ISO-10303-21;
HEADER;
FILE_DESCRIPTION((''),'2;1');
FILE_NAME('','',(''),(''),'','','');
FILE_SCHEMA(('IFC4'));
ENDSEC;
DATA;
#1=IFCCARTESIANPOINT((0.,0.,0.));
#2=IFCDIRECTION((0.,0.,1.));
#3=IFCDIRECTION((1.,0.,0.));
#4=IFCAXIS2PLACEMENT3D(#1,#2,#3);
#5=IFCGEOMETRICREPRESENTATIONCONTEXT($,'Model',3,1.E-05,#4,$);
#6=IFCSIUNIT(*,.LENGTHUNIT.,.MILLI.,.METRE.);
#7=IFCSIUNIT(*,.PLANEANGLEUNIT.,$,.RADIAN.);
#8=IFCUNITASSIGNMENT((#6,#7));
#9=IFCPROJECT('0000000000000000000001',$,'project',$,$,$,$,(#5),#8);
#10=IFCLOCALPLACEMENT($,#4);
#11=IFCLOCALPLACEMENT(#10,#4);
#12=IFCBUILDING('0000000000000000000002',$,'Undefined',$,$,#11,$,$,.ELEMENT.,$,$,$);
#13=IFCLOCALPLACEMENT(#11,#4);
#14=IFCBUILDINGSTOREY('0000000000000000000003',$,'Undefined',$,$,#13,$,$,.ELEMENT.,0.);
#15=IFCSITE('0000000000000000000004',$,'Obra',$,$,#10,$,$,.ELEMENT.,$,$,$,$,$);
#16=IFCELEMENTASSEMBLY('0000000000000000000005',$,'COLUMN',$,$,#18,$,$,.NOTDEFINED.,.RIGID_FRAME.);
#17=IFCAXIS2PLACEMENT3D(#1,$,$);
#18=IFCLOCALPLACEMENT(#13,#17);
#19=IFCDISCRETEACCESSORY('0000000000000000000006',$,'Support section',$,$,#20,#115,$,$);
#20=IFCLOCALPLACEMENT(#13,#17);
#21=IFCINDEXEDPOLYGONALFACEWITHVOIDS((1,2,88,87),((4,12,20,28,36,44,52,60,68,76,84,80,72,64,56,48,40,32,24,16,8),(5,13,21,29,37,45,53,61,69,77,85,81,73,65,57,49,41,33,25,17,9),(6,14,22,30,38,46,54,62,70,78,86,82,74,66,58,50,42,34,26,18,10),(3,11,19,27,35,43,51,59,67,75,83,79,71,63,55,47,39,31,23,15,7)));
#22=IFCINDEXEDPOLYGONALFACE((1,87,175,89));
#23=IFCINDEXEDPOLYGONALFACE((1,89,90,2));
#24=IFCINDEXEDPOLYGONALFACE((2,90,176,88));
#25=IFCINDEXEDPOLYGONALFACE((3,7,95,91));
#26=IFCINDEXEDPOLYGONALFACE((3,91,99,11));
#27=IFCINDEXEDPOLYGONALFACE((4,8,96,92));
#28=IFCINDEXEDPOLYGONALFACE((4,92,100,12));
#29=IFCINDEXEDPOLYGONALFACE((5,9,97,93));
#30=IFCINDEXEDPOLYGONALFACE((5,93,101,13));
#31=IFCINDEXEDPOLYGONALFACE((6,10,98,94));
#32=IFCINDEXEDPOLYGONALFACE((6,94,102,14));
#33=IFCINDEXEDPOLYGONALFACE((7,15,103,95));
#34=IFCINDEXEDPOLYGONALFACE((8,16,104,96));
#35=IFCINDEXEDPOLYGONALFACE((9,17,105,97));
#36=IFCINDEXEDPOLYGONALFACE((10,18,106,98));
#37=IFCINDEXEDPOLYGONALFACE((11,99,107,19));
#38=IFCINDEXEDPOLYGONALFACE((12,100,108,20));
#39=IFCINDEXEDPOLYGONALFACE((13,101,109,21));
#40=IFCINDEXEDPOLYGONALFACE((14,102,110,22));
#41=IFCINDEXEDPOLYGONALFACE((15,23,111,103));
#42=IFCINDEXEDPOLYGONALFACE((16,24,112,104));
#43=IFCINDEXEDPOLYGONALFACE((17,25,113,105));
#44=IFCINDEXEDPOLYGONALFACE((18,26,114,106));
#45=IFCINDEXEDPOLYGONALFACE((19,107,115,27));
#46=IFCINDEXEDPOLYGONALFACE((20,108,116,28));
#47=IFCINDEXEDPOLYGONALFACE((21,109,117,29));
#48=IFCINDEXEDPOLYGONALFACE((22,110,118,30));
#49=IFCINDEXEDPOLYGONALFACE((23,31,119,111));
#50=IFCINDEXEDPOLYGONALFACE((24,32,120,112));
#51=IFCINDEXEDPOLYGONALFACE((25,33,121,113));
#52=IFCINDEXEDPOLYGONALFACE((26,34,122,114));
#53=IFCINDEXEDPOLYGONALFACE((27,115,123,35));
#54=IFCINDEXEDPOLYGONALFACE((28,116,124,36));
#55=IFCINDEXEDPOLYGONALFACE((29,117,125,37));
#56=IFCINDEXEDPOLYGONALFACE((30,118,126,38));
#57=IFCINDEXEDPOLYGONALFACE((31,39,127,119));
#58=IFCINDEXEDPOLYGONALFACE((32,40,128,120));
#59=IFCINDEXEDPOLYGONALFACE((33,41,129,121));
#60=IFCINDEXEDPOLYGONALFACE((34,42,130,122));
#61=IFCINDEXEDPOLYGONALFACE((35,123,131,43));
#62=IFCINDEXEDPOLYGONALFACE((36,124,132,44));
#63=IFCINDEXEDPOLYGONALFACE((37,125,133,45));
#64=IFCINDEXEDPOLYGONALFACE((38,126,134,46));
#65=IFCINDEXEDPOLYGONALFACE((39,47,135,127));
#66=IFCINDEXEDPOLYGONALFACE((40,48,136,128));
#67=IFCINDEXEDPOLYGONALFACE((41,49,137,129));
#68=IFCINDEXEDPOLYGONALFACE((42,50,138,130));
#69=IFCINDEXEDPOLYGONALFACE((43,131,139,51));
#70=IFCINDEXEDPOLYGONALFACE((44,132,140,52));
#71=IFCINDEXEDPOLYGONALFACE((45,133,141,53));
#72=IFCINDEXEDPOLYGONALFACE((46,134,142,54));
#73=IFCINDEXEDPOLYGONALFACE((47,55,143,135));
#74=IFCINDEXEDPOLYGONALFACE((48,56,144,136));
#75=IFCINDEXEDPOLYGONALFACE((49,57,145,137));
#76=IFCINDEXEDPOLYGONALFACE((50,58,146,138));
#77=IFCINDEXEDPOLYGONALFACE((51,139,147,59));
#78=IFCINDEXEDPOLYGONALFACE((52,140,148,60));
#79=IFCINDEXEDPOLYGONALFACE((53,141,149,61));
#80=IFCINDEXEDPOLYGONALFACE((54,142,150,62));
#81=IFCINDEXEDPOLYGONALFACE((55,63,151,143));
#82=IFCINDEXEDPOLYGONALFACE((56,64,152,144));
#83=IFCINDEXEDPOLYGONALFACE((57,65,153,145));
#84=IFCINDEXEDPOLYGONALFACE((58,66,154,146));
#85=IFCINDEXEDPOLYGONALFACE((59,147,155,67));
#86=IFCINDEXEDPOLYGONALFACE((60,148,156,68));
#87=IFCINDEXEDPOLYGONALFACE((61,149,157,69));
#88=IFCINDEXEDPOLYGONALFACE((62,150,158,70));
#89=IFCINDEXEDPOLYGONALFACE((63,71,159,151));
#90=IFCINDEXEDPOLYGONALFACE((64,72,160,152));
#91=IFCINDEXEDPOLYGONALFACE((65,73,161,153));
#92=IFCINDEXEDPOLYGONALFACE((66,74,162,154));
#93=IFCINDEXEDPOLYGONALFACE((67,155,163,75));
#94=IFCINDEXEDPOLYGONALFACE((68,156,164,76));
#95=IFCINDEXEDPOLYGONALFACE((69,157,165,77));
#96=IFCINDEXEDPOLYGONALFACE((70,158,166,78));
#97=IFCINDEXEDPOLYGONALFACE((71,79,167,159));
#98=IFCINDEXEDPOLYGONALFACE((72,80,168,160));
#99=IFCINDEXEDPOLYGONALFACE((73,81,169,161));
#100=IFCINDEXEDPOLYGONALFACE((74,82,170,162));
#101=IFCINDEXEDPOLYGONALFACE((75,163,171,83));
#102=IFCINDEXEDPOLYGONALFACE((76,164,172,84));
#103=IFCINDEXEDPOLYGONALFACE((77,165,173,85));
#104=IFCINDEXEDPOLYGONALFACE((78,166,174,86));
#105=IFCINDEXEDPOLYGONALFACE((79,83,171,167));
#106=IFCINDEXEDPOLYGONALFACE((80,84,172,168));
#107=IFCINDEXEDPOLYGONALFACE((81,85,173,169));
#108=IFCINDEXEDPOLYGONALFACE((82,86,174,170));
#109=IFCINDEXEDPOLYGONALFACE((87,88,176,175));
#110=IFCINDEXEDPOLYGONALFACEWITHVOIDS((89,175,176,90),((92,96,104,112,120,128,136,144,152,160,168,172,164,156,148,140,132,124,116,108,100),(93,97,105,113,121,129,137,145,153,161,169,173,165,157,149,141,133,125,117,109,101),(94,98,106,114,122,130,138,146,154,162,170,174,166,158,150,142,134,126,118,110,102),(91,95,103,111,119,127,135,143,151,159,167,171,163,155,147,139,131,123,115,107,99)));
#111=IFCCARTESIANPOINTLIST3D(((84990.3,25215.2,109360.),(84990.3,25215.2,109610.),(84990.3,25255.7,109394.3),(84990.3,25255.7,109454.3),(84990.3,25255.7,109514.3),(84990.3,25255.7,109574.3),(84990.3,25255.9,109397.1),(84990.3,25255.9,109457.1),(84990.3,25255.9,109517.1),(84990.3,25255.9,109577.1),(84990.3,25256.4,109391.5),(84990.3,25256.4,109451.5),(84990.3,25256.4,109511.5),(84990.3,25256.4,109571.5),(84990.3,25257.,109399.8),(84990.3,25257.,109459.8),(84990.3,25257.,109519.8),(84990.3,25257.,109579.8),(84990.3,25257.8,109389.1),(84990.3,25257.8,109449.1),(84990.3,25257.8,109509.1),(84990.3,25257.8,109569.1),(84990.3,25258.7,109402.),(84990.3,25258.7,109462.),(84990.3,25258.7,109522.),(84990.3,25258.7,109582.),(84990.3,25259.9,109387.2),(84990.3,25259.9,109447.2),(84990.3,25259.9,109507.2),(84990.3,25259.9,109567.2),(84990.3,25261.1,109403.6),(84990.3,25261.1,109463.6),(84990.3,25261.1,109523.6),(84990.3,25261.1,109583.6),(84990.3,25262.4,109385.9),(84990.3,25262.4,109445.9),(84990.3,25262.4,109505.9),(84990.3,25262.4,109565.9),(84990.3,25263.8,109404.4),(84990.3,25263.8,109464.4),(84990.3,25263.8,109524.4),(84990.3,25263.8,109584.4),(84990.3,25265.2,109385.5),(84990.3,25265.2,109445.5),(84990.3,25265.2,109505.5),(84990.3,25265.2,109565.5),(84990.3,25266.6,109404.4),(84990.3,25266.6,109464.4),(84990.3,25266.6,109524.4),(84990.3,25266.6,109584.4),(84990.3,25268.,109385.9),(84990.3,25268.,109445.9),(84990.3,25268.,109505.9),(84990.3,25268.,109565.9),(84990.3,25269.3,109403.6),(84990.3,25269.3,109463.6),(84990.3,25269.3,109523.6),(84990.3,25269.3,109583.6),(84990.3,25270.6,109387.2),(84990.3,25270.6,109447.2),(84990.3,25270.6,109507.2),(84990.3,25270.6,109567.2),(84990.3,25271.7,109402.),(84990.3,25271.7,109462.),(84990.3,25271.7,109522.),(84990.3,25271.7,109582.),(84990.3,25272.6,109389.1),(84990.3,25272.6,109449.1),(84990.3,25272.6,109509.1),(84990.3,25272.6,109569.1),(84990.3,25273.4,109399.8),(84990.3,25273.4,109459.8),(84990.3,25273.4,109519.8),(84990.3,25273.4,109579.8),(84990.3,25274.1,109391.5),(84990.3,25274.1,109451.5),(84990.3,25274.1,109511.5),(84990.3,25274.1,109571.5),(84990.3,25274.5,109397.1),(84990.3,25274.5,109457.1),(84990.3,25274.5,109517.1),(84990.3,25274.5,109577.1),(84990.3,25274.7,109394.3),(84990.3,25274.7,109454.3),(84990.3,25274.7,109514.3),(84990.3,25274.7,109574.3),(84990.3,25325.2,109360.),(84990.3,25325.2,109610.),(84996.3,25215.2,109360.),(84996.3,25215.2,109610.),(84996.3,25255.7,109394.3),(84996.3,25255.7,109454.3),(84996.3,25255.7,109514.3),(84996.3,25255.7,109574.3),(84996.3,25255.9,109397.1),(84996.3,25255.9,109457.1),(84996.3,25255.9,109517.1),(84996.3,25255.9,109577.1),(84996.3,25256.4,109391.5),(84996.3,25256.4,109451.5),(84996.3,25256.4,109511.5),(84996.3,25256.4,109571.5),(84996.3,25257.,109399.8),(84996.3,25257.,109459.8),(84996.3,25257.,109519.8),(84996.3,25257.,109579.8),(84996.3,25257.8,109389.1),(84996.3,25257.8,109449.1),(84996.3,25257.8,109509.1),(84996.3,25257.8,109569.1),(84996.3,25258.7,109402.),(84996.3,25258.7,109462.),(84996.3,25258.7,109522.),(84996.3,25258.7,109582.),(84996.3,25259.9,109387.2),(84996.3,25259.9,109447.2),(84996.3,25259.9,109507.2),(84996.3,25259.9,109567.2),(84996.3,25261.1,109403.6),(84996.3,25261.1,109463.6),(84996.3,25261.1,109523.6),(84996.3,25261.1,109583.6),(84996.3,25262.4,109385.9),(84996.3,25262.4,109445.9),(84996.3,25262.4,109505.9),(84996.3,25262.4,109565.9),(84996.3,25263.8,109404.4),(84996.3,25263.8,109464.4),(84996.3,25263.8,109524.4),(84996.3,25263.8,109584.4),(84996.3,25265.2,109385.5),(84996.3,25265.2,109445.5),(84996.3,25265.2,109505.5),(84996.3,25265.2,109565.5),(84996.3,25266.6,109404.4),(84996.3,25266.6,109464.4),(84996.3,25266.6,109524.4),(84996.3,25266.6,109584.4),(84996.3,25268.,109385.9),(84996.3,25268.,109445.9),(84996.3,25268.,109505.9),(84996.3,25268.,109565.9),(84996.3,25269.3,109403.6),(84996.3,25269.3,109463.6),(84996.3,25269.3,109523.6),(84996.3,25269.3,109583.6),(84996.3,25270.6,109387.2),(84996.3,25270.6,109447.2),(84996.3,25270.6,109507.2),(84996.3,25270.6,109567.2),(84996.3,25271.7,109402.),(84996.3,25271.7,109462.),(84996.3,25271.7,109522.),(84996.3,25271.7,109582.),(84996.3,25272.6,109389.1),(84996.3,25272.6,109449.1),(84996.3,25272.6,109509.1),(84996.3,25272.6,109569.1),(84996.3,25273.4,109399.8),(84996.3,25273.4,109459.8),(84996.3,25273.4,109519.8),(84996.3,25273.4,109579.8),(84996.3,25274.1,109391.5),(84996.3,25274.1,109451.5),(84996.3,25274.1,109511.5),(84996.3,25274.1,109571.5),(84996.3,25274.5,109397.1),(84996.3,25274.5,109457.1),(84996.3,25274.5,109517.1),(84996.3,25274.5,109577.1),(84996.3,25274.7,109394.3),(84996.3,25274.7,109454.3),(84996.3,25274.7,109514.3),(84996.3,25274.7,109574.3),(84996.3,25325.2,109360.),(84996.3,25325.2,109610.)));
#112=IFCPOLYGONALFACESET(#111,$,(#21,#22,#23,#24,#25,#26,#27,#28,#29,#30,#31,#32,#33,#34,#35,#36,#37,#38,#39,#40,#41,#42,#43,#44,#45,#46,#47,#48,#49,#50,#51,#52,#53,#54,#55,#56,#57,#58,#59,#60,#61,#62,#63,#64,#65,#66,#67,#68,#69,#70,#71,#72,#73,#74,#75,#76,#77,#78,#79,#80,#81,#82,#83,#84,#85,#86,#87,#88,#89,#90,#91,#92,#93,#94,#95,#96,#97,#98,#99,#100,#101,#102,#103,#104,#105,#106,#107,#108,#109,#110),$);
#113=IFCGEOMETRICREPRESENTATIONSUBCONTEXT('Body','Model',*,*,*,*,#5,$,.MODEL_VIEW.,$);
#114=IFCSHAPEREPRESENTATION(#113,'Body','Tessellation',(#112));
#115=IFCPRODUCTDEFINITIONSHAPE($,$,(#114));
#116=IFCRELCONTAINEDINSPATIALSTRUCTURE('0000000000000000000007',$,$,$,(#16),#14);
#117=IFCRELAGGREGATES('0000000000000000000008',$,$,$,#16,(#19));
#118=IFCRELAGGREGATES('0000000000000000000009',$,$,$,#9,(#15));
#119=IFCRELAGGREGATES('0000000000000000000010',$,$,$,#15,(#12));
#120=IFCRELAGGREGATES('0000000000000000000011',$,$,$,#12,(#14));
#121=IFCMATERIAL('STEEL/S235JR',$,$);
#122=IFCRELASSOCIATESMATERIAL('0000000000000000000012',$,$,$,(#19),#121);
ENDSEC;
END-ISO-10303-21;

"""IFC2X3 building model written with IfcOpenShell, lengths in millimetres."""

from ifc_helpers import new_model, si_unit, frame, origin_with_axes, origin_2d_with_axis, place, context, subcontext, project, spatial, rectangle, circle, extrude, source, transform, mapped, material, element, aggregate, save


model = new_model("IFC2X3")

# Units and contexts
model_context = context("Model", 3, precision=1e-05, world=origin_with_axes())
body_context = subcontext(model_context, "Body", "Model", "MODEL_VIEW")
ifc_project = project(units=[si_unit("LENGTHUNIT", "METRE", prefix="MILLI"), si_unit("PLANEANGLEUNIT", "RADIAN")], contexts=[model_context])

# Site, building, storey
site_placement = place(None, origin_with_axes())
site = spatial("IfcSite", under=ifc_project, at=site_placement, Name="Obra", CompositionType="ELEMENT")
building_placement = place(site_placement, origin_with_axes())
building = spatial("IfcBuilding", under=site, at=building_placement, Name="Undefined", CompositionType="ELEMENT")
storey_placement = place(building_placement, origin_with_axes())
storey = spatial("IfcBuildingStorey", under=building, at=storey_placement, Name="Undefined", CompositionType="ELEMENT", Elevation=0.0)

# Shared definitions
ifc_material_1 = material(Name="STEEL/S235JR")

# Element assembly, discrete accessory, opening
assembly_1_placement = place(storey_placement, origin_with_axes())
assembly_1 = element("IfcElementAssembly", 1, at=assembly_1_placement, inside=storey, Name="COLUMN", AssemblyPlace="NOTDEFINED", PredefinedType="RIGID_FRAME")
discrete_accessory_1_placement = place(assembly_1_placement, frame((84993.3, 25270.2, 109360.0), z_axis=(0.0, 0.0, 1.0), x_axis=(0.0, 1.0, 0.0)))
discrete_accessory_1 = element("IfcDiscreteAccessory", 2, at=discrete_accessory_1_placement, material=ifc_material_1, Name="Support section", context=body_context, shape_type="SweptSolid", body=[
    extrude(rectangle(XDim=6.0, YDim=110.0, at=origin_2d_with_axis()), frame((0.0, 0.0, 250.0), z_axis=(0.0, 0.0, -1.0), x_axis=(0.0, 1.0, 0.0)), (0.0, 0.0, 1.0), 250.0),
])
shared_shape_1 = source(origin_with_axes(), body_context, "Body", "SweptSolid", [
    extrude(circle(Radius=9.5, at=origin_2d_with_axis()), frame((0.0, -9.8, 0.0), z_axis=(0.0, 1.0, 0.0), x_axis=(1.0, 0.0, 0.0)), (0.0, 0.0, 1.0), 6.2),
])
opening_1_placement = place(assembly_1_placement, frame((85000.0, 25315.2, 109650.0), z_axis=(0.0, -1.0, 0.0), x_axis=(0.0, 0.0, -1.0)))
element("IfcOpeningElement", 3, at=opening_1_placement, cuts=discrete_accessory_1, ObjectType="Opening", context=body_context, shape_type="MappedRepresentation", body=[
    mapped(shared_shape_1, transform((75.0, 0.0, 50.0))),
    mapped(shared_shape_1, transform((135.0, 0.0, 50.0))),
    mapped(shared_shape_1, transform((195.0, 0.0, 50.0))),
    mapped(shared_shape_1, transform((255.0, 0.0, 50.0))),
])
aggregate(assembly_1, [discrete_accessory_1])

save(model, "model.ifc")
